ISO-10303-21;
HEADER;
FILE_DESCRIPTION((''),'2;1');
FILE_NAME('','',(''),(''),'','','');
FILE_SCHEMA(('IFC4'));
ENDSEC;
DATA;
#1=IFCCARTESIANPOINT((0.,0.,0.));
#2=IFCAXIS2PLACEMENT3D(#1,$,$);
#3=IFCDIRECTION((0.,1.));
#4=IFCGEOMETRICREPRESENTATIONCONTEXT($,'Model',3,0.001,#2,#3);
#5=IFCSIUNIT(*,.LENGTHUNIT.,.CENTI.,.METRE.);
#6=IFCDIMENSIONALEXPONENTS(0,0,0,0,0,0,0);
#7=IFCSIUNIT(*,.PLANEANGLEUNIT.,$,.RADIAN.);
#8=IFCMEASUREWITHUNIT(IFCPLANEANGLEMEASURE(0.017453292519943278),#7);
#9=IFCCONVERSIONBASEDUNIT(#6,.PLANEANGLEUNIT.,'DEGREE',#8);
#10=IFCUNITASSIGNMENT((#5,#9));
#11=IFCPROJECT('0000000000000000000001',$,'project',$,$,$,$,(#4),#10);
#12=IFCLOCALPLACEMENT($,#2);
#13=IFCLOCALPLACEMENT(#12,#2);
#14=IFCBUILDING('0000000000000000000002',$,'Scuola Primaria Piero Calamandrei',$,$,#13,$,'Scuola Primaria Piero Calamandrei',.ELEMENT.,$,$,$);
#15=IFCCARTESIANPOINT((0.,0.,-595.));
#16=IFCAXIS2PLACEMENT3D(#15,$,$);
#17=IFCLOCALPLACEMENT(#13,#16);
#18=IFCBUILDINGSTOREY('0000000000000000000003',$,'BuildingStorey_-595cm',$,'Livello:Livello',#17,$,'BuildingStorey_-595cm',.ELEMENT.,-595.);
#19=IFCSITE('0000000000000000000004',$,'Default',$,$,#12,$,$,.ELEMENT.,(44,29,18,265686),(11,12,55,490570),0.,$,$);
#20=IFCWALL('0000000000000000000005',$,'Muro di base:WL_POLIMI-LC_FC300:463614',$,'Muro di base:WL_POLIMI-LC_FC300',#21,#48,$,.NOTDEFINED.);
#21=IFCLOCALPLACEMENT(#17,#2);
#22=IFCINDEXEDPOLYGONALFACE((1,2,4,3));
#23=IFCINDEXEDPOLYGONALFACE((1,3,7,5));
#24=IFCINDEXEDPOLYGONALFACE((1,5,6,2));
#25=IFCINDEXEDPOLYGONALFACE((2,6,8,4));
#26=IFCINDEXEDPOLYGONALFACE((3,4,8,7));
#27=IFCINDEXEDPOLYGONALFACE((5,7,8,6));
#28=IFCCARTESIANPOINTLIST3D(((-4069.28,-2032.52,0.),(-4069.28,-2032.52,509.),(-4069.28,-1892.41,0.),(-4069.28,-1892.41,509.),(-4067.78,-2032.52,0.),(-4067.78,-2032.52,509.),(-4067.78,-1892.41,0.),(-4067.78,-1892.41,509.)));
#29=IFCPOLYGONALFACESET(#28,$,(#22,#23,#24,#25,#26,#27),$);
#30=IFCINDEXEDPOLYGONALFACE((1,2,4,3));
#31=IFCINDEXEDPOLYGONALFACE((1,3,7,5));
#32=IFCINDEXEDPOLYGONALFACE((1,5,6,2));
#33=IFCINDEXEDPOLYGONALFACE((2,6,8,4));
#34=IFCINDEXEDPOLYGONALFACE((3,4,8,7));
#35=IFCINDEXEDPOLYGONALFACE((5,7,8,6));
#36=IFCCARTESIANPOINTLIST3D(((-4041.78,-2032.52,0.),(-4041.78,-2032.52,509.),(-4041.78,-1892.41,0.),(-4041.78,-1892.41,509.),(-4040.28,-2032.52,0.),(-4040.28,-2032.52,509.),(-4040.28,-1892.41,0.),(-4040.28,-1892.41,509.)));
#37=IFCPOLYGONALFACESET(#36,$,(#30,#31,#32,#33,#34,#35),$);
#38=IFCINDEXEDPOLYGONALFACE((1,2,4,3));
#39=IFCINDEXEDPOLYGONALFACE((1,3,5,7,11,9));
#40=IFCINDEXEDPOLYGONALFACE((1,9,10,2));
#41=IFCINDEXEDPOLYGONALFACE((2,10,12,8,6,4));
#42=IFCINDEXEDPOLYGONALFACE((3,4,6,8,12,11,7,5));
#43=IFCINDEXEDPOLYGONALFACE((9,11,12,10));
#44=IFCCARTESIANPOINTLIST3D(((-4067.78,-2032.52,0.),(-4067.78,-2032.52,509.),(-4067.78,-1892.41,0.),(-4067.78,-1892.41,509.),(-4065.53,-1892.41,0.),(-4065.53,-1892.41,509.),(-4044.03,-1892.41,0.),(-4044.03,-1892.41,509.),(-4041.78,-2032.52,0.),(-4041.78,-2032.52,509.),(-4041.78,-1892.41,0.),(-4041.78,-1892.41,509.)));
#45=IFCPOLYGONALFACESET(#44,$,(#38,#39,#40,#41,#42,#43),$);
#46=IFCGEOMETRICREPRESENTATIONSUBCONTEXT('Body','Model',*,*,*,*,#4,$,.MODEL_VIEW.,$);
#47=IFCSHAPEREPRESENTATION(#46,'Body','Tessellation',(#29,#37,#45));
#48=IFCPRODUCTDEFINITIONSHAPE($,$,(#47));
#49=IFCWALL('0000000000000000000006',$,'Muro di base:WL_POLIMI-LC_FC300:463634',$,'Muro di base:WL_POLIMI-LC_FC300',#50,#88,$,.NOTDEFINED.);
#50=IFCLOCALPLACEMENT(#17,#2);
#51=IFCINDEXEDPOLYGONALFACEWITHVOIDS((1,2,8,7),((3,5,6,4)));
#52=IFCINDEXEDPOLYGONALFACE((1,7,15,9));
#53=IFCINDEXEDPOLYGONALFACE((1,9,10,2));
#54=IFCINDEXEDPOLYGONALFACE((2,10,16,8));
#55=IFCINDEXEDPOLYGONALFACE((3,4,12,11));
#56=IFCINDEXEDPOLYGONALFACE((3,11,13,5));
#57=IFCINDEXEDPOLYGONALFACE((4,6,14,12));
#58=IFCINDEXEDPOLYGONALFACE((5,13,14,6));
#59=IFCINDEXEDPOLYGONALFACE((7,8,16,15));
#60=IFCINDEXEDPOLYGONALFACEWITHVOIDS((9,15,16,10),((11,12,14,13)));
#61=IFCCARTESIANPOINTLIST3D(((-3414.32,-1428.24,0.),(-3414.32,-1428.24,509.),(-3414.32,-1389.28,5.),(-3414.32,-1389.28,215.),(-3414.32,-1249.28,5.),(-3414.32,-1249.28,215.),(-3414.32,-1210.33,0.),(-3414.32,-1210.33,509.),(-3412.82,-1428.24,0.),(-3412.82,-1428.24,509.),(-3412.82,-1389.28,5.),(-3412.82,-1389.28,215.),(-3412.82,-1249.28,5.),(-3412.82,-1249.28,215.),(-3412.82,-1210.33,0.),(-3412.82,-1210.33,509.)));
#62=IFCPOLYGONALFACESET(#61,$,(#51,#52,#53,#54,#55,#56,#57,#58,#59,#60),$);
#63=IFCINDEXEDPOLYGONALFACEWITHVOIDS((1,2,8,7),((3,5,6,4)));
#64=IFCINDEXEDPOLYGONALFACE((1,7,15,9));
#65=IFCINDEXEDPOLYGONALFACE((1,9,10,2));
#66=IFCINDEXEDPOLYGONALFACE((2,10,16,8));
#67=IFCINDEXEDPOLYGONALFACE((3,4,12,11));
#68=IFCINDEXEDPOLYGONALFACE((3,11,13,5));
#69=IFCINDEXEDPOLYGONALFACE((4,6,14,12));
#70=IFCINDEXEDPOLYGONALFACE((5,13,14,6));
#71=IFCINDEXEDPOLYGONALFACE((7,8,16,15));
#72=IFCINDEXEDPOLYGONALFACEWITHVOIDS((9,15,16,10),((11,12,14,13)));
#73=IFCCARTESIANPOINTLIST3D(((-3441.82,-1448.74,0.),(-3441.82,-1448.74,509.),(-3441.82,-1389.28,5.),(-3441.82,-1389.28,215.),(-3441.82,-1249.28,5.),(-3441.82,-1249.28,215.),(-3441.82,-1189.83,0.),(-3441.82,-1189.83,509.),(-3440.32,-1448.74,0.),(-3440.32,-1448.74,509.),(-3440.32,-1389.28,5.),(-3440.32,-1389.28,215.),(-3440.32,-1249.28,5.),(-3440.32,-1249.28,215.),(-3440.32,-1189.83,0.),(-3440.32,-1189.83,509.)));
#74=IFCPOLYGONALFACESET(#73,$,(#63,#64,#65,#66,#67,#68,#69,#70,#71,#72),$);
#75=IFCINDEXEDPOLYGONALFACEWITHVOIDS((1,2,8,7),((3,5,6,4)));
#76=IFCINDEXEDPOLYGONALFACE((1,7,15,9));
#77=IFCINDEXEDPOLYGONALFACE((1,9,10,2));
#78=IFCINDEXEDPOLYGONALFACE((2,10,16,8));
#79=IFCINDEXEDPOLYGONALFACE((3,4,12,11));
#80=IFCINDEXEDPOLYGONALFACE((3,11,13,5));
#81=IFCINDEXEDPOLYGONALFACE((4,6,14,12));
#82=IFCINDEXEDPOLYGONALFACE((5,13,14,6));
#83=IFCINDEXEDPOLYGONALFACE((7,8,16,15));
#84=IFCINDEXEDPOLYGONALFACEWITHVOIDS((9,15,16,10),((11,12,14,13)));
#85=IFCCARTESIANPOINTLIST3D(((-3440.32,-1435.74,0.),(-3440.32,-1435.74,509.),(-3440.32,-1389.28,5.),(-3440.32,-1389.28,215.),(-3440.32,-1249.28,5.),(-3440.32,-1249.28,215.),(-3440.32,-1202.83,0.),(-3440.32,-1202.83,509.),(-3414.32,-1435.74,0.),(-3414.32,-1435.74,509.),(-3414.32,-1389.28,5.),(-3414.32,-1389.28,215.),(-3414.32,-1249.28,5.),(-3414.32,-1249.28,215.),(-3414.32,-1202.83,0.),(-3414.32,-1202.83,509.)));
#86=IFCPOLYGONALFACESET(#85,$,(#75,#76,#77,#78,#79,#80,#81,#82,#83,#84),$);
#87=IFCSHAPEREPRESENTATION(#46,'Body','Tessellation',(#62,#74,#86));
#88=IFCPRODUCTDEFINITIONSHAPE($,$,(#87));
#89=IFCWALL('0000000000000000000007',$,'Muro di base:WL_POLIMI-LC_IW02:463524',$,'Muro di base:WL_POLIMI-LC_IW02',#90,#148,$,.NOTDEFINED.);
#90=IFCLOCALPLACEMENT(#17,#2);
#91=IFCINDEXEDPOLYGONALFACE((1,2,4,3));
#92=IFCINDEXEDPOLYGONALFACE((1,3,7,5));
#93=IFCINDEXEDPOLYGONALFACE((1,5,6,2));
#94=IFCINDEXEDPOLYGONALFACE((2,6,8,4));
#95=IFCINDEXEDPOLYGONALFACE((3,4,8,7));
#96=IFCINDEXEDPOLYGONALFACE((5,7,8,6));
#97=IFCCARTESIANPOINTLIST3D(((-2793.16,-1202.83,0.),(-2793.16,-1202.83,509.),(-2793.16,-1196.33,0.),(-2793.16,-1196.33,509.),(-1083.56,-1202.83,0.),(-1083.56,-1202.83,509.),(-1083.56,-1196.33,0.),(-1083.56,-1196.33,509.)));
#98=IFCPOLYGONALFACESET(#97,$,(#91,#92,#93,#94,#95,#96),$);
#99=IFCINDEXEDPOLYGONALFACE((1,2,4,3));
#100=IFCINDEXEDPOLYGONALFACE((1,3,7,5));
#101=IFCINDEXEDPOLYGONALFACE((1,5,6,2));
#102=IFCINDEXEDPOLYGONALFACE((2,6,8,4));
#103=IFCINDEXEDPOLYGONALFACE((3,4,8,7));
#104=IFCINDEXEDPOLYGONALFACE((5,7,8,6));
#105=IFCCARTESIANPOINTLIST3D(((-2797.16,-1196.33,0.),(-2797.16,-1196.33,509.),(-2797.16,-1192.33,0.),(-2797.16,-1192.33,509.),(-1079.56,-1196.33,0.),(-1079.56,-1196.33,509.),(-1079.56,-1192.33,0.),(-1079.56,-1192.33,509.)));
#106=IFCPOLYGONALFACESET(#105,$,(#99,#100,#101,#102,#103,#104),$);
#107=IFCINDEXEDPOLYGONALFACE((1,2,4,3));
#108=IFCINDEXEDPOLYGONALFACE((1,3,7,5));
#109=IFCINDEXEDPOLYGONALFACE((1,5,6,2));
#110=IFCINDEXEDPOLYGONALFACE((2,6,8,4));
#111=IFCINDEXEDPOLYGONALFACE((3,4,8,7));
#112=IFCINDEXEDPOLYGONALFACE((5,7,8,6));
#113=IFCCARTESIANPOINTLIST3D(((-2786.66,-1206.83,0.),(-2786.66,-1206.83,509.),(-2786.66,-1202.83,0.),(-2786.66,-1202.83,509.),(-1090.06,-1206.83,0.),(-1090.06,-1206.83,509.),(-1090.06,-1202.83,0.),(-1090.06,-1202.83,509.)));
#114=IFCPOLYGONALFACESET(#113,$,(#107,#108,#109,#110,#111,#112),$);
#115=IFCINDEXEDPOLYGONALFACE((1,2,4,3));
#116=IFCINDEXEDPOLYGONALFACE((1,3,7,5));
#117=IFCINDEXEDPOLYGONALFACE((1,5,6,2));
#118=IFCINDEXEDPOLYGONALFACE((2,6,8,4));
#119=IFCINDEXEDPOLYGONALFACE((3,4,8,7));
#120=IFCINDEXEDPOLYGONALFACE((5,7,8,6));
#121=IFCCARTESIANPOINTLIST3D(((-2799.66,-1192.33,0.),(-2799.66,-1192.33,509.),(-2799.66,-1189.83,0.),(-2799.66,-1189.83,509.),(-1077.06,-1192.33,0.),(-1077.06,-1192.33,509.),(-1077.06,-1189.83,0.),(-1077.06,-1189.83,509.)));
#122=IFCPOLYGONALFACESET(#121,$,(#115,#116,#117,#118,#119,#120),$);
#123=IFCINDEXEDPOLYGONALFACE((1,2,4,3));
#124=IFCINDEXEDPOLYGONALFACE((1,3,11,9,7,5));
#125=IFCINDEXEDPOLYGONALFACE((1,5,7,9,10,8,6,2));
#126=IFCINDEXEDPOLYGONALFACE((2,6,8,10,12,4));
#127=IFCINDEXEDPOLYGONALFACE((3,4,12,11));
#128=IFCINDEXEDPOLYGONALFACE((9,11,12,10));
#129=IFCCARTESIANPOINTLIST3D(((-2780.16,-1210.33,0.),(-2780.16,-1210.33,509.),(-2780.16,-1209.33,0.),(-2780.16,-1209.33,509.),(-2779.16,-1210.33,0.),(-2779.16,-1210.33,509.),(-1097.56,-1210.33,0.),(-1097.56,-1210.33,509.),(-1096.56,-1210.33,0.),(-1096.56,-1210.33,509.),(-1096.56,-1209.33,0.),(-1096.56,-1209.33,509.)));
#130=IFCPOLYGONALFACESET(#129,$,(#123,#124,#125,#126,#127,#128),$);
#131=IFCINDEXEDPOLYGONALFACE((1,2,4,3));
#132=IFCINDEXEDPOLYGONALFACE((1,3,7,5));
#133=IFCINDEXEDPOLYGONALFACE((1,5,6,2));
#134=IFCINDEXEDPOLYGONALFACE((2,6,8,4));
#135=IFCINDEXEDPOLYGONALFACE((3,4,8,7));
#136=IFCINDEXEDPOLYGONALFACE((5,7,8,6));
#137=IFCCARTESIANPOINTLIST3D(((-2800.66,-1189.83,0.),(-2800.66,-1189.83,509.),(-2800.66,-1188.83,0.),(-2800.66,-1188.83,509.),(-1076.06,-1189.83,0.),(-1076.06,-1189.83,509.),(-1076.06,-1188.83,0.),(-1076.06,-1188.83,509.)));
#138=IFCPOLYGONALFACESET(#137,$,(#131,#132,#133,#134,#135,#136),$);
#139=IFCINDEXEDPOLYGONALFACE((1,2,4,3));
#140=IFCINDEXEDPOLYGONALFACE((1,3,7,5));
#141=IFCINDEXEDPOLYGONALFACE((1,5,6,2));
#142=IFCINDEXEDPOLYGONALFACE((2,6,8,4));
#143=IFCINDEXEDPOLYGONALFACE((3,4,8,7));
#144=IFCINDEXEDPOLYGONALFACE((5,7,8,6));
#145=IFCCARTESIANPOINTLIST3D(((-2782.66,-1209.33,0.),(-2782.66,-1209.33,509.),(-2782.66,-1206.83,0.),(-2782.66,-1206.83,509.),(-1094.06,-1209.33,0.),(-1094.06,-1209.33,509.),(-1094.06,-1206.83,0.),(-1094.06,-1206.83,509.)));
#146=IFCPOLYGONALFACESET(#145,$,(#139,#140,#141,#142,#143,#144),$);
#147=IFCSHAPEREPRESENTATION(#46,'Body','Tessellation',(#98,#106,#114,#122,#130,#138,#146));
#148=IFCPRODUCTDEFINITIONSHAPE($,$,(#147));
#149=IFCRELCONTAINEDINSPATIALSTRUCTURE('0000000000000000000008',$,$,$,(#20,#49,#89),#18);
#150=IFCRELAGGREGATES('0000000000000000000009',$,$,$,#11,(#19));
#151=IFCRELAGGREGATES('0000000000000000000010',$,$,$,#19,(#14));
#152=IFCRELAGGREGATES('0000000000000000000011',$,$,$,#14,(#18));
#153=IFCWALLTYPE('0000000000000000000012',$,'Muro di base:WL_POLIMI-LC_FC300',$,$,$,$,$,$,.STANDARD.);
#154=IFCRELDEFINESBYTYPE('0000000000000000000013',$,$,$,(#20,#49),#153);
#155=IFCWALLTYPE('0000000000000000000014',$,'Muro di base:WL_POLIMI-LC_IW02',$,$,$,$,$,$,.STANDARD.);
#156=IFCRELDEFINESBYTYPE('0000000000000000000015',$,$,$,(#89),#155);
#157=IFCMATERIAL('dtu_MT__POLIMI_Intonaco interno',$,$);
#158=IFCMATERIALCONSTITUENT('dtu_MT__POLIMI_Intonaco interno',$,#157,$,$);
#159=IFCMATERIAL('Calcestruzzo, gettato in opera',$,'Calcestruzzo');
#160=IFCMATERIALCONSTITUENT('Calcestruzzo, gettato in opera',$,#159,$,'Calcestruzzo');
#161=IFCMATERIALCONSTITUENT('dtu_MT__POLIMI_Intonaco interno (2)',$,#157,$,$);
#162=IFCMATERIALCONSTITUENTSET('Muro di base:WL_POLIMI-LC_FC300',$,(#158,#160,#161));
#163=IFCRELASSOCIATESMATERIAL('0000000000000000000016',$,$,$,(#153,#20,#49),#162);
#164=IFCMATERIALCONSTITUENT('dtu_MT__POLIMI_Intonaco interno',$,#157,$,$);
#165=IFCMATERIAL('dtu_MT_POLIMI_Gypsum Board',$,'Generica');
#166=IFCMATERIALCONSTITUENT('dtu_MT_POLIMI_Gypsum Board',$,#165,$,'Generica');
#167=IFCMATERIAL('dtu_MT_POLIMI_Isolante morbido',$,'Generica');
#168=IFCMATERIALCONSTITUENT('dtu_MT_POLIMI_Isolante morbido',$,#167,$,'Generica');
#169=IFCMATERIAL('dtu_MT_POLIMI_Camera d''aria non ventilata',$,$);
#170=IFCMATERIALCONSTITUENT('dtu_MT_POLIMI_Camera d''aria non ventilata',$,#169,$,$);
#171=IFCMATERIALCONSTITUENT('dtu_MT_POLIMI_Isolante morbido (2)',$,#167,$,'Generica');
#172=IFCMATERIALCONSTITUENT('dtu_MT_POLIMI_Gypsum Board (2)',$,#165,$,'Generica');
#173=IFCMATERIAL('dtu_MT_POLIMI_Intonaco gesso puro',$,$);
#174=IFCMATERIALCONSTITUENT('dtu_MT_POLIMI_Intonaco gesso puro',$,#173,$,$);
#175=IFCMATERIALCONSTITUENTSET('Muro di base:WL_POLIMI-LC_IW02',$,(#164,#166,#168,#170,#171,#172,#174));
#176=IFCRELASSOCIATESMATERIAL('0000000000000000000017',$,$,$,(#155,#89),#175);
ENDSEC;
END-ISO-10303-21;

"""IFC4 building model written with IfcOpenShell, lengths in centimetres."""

from ifc_helpers import new_model, entity, si_unit, converted_unit, direction, frame, origin, place, context, subcontext, project, spatial, indexed_curve, outline, extrude, material, constituent, constituent_set, type_object, element, save


model = new_model("IFC4")

# Units and contexts
model_context = context("Model", 3, precision=0.001, world=origin(), true_north=direction((0.0, 1.0)))
body_context = subcontext(model_context, "Body", "Model", "MODEL_VIEW")
ifc_project = project(units=[si_unit("LENGTHUNIT", "METRE", prefix="CENTI"), converted_unit("PLANEANGLEUNIT", "DEGREE", entity("IfcPlaneAngleMeasure", 0.017453292519943278), si_unit("PLANEANGLEUNIT", "RADIAN"), dimensions=[0, 0, 0, 0, 0, 0, 0])], contexts=[model_context])

# Site, building, storey
site_placement = place(None, origin())
site = spatial("IfcSite", under=ifc_project, at=site_placement, Name="Default", CompositionType="ELEMENT", RefLatitude=(44, 29, 18, 265686), RefLongitude=(11, 12, 55, 490570), RefElevation=0.0)
building_placement = place(site_placement, origin())
building = spatial("IfcBuilding", under=site, at=building_placement, Name="Scuola Primaria Piero Calamandrei", LongName="Scuola Primaria Piero Calamandrei", CompositionType="ELEMENT")
storey_placement = place(building_placement, frame((0.0, 0.0, -595.0)))
storey = spatial("IfcBuildingStorey", under=building, at=storey_placement, Name="BuildingStorey_-595cm", ObjectType="Livello:Livello", LongName="BuildingStorey_-595cm", CompositionType="ELEMENT", Elevation=-595.0)

# Wall
ifc_material_1 = material(Name="dtu_MT__POLIMI_Intonaco interno")
ifc_constituent_1 = constituent(ifc_material_1, Name="dtu_MT__POLIMI_Intonaco interno")
ifc_material_2 = material(Name="Calcestruzzo, gettato in opera", Category="Calcestruzzo")
ifc_constituent_2 = constituent(ifc_material_2, Name="Calcestruzzo, gettato in opera", Category="Calcestruzzo")
ifc_constituent_3 = constituent(ifc_material_1, Name="dtu_MT__POLIMI_Intonaco interno (2)")
ifc_constituent_set_1 = constituent_set(constituents=[ifc_constituent_1, ifc_constituent_2, ifc_constituent_3], Name="Muro di base:WL_POLIMI-LC_FC300")
wall_type_1 = type_object("IfcWallType", Name="Muro di base:WL_POLIMI-LC_FC300", PredefinedType="STANDARD", material=ifc_constituent_set_1)
wall_1_placement = place(storey_placement, frame((-4054.78, -1892.41, 0.0), z_axis=(0.0, 0.0, 1.0), x_axis=(0.0, -1.0, 0.0)))
element("IfcWall", 1, at=wall_1_placement, inside=storey, type_object=wall_type_1, material=ifc_constituent_set_1, Name="Muro di base:WL_POLIMI-LC_FC300:463614", ObjectType="Muro di base:WL_POLIMI-LC_FC300", PredefinedType="NOTDEFINED", context=body_context, shape_type="SweptSolid", body=[
    extrude(outline(indexed_curve([(-0.75, -70.05), (0.75, -70.05), (0.75, 70.05), (-0.75, 70.05), (-0.75, -70.05)], self_intersect=False)), frame((70.05, -13.75, 0.0), z_axis=(0.0, 0.0, 1.0), x_axis=(0.0, 1.0, 0.0)), (0.0, 0.0, 1.0), 509.0),
    extrude(outline(indexed_curve([(-0.75, -70.05), (0.75, -70.05), (0.75, 70.05), (-0.75, 70.05), (-0.75, -70.05)], self_intersect=False)), frame((70.05, 13.75, 0.0), z_axis=(0.0, 0.0, 1.0), x_axis=(0.0, -1.0, 0.0)), (0.0, 0.0, 1.0), 509.0),
    extrude(outline(indexed_curve([(10.75, -46.7), (13.0, -46.7), (13.0, 93.41), (-13.0, 93.41), (-13.0, -46.7), (-10.75, -46.7), (10.75, -46.7)], self_intersect=False)), frame((46.7, 0.0, 0.0), z_axis=(0.0, 0.0, 1.0), x_axis=(0.0, -1.0, 0.0)), (0.0, 0.0, 1.0), 509.0),
])

# Wall, opening
wall_2_placement = place(storey_placement, frame((-3427.32, -1428.24, 0.0), z_axis=(0.0, 0.0, 1.0), x_axis=(0.0, 1.0, 0.0)))
wall_2 = element("IfcWall", 2, at=wall_2_placement, inside=storey, type_object=wall_type_1, material=ifc_constituent_set_1, Name="Muro di base:WL_POLIMI-LC_FC300:463634", ObjectType="Muro di base:WL_POLIMI-LC_FC300", PredefinedType="NOTDEFINED", context=body_context, shape_type="SweptSolid", body=[
    extrude(outline(indexed_curve([(-254.5, -108.96), (254.5, -108.96), (254.5, 108.96), (-254.5, 108.96), (-254.5, -108.96)], self_intersect=False), holes=[indexed_curve([(-249.5, -70.0), (-249.5, 70.0), (-39.5, 70.0), (-39.5, -70.0), (-249.5, -70.0)], self_intersect=False)]), frame((108.96, -13.0, 254.5), z_axis=(0.0, -1.0, 0.0), x_axis=(0.0, 0.0, 1.0)), (0.0, 0.0, 1.0), 1.5),
    extrude(outline(indexed_curve([(-129.46, -254.5), (-105.21, -254.5), (105.21, -254.5), (129.46, -254.5), (129.46, 254.5), (105.21, 254.5), (-105.21, 254.5), (-129.46, 254.5), (-129.46, -254.5)], self_intersect=False), holes=[indexed_curve([(70.0, -249.5), (-70.0, -249.5), (-70.0, -39.5), (70.0, -39.5), (70.0, -249.5)], self_intersect=False)]), frame((108.96, 14.5, 254.5), z_axis=(0.0, -1.0, 0.0), x_axis=(1.0, 0.0, 0.0)), (0.0, 0.0, 1.0), 1.5),
    extrude(outline(indexed_curve([(-254.5, -116.46), (254.5, -116.46), (254.5, 116.46), (-254.5, 116.46), (-254.5, -116.46)], self_intersect=False), holes=[indexed_curve([(-249.5, -70.0), (-249.5, 70.0), (-39.5, 70.0), (-39.5, -70.0), (-249.5, -70.0)], self_intersect=False)]), frame((108.96, 13.0, 254.5), z_axis=(0.0, -1.0, 0.0), x_axis=(0.0, 0.0, 1.0)), (0.0, 0.0, 1.0), 26.0),
])
opening_1_placement = place(wall_2_placement, frame((1428.24, -3427.32, 0.0), z_axis=(0.0, 0.0, 1.0), x_axis=(0.0, -1.0, 0.0)))
element("IfcOpeningElement", 3, at=opening_1_placement, cuts=wall_2, PredefinedType="OPENING", context=body_context, shape_type="SweptSolid", body=[
    extrude(outline(indexed_curve([(-70.0, -105.0), (70.0, -105.0), (70.0, 105.0), (-70.0, 105.0), (-70.0, -105.0)], self_intersect=False)), frame((-3260.42, -1319.28, 110.0), z_axis=(-1.0, 0.0, 0.0), x_axis=(0.0, -1.0, 0.0)), (0.0, 0.0, 1.0), 304.8),
])

# Wall
ifc_constituent_4 = constituent(ifc_material_1, Name="dtu_MT__POLIMI_Intonaco interno")
ifc_material_3 = material(Name="dtu_MT_POLIMI_Gypsum Board", Category="Generica")
ifc_constituent_5 = constituent(ifc_material_3, Name="dtu_MT_POLIMI_Gypsum Board", Category="Generica")
ifc_material_4 = material(Name="dtu_MT_POLIMI_Isolante morbido", Category="Generica")
ifc_constituent_6 = constituent(ifc_material_4, Name="dtu_MT_POLIMI_Isolante morbido", Category="Generica")
ifc_material_5 = material(Name="dtu_MT_POLIMI_Camera d'aria non ventilata")
ifc_constituent_7 = constituent(ifc_material_5, Name="dtu_MT_POLIMI_Camera d'aria non ventilata")
ifc_constituent_8 = constituent(ifc_material_4, Name="dtu_MT_POLIMI_Isolante morbido (2)", Category="Generica")
ifc_constituent_9 = constituent(ifc_material_3, Name="dtu_MT_POLIMI_Gypsum Board (2)", Category="Generica")
ifc_material_6 = material(Name="dtu_MT_POLIMI_Intonaco gesso puro")
ifc_constituent_10 = constituent(ifc_material_6, Name="dtu_MT_POLIMI_Intonaco gesso puro")
ifc_constituent_set_2 = constituent_set(constituents=[ifc_constituent_4, ifc_constituent_5, ifc_constituent_6, ifc_constituent_7, ifc_constituent_8, ifc_constituent_9, ifc_constituent_10], Name="Muro di base:WL_POLIMI-LC_IW02")
wall_type_2 = type_object("IfcWallType", Name="Muro di base:WL_POLIMI-LC_IW02", PredefinedType="STANDARD", material=ifc_constituent_set_2)
wall_3_placement = place(storey_placement, frame((-2800.66, -1199.58, 0.0)))
element("IfcWall", 4, at=wall_3_placement, inside=storey, type_object=wall_type_2, material=ifc_constituent_set_2, Name="Muro di base:WL_POLIMI-LC_IW02:463524", ObjectType="Muro di base:WL_POLIMI-LC_IW02", PredefinedType="NOTDEFINED", context=body_context, shape_type="SweptSolid", body=[
    extrude(outline(indexed_curve([(-854.8, -3.25), (854.8, -3.25), (854.8, 3.25), (-854.8, 3.25), (-854.8, -3.25)], self_intersect=False)), frame((862.3, 0.0, 0.0)), (0.0, 0.0, 1.0), 509.0),
    extrude(outline(indexed_curve([(-858.8, -2.0), (858.8, -2.0), (858.8, 2.0), (-858.8, 2.0), (-858.8, -2.0)], self_intersect=False)), frame((862.3, 5.25, 0.0)), (0.0, 0.0, 1.0), 509.0),
    extrude(outline(indexed_curve([(-848.3, -2.0), (848.3, -2.0), (848.3, 2.0), (-848.3, 2.0), (-848.3, -2.0)], self_intersect=False)), frame((862.3, -5.25, 0.0)), (0.0, 0.0, 1.0), 509.0),
    extrude(outline(indexed_curve([(-861.3, -1.25), (861.3, -1.25), (861.3, 1.25), (-861.3, 1.25), (-861.3, -1.25)], self_intersect=False)), frame((862.3, 8.5, 0.0)), (0.0, 0.0, 1.0), 509.0),
    extrude(outline(indexed_curve([(-840.8, -0.33), (840.8, -0.33), (841.8, -0.33), (841.8, 0.67), (-841.8, 0.67), (-841.8, -0.33), (-840.8, -0.33)], self_intersect=False)), frame((862.3, -10.42, 0.0)), (0.0, 0.0, 1.0), 509.0),
    extrude(outline(indexed_curve([(-0.5, -862.3), (0.5, -862.3), (0.5, 862.3), (-0.5, 862.3), (-0.5, -862.3)], self_intersect=False)), frame((862.3, 10.25, 0.0), z_axis=(0.0, 0.0, 1.0), x_axis=(0.0, -1.0, 0.0)), (0.0, 0.0, 1.0), 509.0),
    extrude(outline(indexed_curve([(-844.3, -1.25), (844.3, -1.25), (844.3, 1.25), (-844.3, 1.25), (-844.3, -1.25)], self_intersect=False)), frame((862.3, -8.5, 0.0)), (0.0, 0.0, 1.0), 509.0),
])

save(model, "model.ifc")
